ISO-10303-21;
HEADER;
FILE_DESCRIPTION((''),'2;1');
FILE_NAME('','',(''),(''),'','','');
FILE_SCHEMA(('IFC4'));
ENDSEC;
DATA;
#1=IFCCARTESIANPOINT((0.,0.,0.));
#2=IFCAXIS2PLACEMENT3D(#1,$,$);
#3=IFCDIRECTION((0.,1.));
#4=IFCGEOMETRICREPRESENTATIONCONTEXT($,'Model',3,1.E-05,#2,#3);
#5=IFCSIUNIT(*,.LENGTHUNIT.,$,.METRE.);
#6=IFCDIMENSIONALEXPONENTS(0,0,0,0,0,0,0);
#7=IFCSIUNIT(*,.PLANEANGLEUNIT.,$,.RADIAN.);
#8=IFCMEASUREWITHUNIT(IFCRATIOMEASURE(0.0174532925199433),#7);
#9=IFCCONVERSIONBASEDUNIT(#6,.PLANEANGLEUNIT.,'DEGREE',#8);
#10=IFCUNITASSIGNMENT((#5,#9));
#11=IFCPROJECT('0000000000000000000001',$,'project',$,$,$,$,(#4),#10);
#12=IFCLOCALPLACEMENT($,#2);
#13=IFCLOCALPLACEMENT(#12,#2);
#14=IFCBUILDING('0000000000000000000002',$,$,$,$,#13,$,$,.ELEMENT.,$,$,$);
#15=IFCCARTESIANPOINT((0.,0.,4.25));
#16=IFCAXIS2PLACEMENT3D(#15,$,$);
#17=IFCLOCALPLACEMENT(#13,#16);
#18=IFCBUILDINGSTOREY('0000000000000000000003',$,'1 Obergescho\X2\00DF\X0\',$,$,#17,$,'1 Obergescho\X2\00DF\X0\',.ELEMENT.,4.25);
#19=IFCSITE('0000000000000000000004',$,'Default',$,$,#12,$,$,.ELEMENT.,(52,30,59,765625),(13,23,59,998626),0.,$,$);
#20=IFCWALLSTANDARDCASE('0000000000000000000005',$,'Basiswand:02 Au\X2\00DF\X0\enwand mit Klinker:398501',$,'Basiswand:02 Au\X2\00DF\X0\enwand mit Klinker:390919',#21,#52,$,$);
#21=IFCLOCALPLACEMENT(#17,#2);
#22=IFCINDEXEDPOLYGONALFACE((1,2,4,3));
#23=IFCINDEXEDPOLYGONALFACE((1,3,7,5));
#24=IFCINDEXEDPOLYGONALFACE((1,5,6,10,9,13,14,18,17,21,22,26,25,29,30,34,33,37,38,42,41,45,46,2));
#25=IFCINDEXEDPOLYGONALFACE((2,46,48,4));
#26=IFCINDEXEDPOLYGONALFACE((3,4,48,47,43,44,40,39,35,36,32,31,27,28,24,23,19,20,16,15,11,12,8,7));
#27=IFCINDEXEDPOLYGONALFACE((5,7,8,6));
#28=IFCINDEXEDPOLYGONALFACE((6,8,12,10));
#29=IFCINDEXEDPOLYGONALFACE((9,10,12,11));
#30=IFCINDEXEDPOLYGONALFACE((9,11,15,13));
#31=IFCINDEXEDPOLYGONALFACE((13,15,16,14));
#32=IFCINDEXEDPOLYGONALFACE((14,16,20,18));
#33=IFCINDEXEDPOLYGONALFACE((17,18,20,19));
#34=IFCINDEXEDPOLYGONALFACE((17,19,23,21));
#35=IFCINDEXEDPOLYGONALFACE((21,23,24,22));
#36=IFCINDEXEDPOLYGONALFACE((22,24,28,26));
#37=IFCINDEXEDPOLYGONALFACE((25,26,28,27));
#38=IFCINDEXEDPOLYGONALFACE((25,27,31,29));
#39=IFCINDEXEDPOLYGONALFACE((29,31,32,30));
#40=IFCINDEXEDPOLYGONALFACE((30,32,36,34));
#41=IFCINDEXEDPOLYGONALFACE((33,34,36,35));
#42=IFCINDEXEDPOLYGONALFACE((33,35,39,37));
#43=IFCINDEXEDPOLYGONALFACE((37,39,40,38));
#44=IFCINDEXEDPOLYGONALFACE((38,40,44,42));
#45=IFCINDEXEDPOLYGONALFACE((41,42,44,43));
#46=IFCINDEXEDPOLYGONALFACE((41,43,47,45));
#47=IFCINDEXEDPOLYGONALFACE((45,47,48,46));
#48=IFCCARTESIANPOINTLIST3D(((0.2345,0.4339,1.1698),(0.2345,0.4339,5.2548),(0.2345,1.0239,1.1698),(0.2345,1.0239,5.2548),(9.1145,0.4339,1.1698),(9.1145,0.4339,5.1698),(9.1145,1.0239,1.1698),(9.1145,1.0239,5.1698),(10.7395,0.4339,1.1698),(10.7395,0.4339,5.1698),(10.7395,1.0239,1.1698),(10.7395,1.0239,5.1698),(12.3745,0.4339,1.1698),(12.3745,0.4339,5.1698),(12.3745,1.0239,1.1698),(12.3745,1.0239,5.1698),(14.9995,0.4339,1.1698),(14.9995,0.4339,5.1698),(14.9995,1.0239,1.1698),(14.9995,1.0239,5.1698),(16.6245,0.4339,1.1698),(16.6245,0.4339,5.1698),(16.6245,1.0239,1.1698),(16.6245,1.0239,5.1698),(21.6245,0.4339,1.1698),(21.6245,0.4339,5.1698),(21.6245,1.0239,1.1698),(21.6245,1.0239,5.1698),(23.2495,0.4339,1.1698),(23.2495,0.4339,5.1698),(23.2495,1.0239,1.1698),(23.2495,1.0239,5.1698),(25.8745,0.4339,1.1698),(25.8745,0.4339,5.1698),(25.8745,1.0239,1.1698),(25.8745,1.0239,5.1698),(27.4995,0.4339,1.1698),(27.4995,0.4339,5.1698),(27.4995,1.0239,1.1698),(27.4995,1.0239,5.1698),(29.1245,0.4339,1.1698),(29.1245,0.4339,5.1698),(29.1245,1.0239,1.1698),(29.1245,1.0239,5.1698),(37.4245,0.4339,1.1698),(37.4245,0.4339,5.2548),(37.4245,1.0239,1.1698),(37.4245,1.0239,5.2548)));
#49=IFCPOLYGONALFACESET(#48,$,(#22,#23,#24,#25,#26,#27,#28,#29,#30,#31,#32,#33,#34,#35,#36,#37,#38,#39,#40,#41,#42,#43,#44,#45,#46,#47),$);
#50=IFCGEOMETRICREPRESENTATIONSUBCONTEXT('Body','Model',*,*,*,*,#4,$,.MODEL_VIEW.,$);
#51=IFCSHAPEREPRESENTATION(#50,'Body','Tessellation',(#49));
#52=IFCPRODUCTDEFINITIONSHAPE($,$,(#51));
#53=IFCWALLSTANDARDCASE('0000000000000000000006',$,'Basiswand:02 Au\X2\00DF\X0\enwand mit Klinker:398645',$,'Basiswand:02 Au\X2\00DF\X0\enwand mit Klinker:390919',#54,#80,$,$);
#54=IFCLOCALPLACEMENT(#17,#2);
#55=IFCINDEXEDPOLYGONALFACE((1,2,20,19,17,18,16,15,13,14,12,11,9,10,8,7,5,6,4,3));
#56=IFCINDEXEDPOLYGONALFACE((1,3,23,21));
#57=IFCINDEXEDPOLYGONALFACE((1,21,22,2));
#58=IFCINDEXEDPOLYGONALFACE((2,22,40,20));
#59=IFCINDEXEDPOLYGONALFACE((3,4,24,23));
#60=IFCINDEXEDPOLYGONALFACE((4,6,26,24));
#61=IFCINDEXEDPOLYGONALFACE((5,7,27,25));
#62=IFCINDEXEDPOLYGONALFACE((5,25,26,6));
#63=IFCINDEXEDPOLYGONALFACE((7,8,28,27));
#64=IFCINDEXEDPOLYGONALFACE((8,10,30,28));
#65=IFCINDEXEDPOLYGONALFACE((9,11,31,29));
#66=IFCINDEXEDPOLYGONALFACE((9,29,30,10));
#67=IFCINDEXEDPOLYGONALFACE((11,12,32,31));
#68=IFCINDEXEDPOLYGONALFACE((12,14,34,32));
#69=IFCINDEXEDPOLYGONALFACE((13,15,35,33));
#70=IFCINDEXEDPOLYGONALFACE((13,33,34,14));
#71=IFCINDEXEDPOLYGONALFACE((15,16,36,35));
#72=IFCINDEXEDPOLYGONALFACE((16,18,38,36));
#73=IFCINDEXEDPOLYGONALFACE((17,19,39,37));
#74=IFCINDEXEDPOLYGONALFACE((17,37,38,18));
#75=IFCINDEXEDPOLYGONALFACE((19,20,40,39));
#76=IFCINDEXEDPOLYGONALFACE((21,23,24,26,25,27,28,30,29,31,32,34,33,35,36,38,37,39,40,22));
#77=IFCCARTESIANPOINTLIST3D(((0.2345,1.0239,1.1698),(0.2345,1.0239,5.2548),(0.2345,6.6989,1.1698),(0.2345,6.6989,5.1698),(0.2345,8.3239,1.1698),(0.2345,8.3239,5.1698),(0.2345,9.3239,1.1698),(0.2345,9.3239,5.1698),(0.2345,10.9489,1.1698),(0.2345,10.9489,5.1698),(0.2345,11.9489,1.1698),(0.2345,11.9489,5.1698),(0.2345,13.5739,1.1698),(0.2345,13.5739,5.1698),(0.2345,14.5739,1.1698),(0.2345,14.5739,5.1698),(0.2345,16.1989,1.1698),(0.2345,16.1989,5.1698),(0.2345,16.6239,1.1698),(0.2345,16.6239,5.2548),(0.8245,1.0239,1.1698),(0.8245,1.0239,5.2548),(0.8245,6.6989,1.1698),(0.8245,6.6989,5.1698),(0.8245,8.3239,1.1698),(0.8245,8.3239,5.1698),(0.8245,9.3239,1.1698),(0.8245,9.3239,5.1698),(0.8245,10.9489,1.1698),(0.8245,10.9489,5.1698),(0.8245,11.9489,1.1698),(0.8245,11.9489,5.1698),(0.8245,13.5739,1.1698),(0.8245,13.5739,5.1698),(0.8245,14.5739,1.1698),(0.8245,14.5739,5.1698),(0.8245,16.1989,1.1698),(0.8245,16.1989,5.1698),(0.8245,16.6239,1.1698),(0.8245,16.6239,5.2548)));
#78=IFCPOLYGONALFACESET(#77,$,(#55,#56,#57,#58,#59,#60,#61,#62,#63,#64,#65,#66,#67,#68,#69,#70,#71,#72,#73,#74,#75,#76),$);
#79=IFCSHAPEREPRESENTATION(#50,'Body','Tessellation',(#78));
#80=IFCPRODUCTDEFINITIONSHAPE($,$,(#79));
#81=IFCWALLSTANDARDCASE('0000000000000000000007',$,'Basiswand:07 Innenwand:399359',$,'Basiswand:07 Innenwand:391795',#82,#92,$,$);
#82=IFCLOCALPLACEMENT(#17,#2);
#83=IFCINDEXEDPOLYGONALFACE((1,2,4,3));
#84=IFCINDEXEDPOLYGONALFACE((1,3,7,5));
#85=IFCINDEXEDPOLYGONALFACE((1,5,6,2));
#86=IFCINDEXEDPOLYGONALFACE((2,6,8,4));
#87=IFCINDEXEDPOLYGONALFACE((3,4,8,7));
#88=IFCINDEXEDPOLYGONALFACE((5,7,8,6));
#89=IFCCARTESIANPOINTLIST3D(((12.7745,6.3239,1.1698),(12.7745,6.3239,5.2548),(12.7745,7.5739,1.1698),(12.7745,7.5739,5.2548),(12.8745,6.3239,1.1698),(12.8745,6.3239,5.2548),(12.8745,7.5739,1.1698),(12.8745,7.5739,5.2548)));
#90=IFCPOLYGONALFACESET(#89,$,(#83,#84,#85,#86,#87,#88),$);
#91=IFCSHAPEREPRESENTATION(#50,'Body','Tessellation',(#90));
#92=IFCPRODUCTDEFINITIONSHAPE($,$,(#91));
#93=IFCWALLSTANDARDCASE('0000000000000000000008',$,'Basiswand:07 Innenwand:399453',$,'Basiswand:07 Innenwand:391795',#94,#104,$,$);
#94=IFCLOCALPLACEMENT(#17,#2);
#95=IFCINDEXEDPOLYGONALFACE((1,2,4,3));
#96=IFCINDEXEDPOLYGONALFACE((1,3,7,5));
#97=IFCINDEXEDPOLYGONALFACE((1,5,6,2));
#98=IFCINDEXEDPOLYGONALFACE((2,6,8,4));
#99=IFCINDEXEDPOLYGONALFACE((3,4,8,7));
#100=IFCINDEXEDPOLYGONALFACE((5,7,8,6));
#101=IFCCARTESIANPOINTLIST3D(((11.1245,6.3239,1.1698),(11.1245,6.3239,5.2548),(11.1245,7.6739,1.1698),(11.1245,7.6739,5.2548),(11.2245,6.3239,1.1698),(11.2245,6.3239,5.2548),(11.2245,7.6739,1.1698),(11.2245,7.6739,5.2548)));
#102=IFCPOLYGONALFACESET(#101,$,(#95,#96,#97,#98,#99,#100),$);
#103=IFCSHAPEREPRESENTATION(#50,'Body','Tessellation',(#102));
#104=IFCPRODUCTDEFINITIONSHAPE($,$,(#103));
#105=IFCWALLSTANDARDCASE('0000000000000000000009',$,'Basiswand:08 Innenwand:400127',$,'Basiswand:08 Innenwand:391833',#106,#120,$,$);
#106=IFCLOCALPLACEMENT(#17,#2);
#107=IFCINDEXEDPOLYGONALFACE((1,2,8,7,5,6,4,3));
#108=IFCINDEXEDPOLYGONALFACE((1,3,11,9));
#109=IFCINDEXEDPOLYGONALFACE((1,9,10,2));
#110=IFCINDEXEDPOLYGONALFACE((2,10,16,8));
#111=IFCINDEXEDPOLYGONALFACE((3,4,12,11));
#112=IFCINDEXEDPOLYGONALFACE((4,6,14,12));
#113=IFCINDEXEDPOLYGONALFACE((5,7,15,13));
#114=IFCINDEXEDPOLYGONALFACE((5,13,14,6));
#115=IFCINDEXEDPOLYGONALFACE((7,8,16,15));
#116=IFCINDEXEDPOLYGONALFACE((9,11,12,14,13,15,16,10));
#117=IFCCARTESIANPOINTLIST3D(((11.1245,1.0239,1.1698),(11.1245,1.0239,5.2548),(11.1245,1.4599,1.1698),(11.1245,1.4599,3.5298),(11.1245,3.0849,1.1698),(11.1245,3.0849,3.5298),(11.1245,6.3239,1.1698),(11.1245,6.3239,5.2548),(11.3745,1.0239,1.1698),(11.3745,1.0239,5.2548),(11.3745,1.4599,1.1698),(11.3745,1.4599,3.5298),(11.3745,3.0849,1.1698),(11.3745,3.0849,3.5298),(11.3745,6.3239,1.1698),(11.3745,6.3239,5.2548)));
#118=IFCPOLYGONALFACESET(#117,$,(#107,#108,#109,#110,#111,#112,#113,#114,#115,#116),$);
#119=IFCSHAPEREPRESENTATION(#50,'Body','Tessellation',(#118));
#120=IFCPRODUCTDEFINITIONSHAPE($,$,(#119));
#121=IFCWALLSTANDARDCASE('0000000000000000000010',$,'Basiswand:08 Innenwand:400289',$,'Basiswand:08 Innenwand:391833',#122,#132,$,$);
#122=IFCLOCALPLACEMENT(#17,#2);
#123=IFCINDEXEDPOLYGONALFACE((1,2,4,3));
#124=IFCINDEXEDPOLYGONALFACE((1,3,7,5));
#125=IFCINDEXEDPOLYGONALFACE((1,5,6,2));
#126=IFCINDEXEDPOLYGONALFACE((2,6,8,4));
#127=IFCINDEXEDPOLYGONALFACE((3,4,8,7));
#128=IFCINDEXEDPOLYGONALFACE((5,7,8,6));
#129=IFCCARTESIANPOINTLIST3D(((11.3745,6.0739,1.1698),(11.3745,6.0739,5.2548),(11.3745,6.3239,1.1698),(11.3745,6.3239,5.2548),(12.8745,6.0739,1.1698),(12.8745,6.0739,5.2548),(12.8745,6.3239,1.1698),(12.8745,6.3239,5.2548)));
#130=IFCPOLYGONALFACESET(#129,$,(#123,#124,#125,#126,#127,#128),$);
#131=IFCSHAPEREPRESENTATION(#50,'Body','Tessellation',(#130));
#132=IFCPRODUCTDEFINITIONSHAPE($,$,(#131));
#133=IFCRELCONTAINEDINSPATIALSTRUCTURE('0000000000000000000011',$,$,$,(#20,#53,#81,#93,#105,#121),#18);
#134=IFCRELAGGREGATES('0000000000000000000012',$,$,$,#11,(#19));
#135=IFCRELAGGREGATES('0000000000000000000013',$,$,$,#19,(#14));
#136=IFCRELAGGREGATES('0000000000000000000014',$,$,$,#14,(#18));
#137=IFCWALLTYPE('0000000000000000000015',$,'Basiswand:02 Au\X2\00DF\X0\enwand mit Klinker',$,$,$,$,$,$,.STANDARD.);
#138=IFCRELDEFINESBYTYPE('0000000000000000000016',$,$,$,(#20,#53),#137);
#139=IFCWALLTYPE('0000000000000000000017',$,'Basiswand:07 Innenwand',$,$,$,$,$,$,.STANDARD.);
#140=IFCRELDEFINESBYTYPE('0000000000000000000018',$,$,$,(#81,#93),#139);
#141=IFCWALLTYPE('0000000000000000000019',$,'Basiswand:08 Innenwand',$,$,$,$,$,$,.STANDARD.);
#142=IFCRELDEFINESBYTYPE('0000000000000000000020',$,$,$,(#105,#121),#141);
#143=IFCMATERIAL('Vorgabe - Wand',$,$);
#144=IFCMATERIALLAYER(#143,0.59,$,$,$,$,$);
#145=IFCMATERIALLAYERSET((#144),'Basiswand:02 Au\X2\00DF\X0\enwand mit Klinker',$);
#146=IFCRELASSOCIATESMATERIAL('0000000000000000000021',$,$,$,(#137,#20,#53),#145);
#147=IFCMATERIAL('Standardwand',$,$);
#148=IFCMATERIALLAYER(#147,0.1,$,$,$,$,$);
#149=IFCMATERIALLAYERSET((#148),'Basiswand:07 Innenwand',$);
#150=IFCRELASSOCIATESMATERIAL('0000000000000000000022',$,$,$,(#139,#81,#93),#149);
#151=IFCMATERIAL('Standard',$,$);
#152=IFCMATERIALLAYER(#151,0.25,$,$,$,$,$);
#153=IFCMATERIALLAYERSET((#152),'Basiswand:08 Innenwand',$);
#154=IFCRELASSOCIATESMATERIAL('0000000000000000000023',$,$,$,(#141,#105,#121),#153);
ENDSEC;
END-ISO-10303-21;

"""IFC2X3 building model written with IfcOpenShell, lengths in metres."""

from ifc_helpers import new_model, entity, si_unit, converted_unit, direction, frame, frame_2d, origin, place, context, subcontext, project, spatial, polyline, rectangle, extrude, clip, bounded_halfspace, material, layer, layer_set, layer_usage, type_object, element, save


model = new_model("IFC2X3")

# Units and contexts
model_context = context("Model", 3, precision=1e-05, world=origin(), true_north=direction((0.0, 1.0)))
body_context = subcontext(model_context, "Body", "Model", "MODEL_VIEW")
ifc_project = project(units=[si_unit("LENGTHUNIT", "METRE"), converted_unit("PLANEANGLEUNIT", "DEGREE", entity("IfcRatioMeasure", 0.0174532925199433), si_unit("PLANEANGLEUNIT", "RADIAN"), dimensions=[0, 0, 0, 0, 0, 0, 0])], contexts=[model_context])

# Site, building, storey
site_placement = place(None, origin())
site = spatial("IfcSite", under=ifc_project, at=site_placement, Name="Default", CompositionType="ELEMENT", RefLatitude=(52, 30, 59, 765625), RefLongitude=(13, 23, 59, 998626), RefElevation=0.0)
building_placement = place(site_placement, origin())
building = spatial("IfcBuilding", under=site, at=building_placement, CompositionType="ELEMENT")
storey_placement = place(building_placement, frame((0.0, 0.0, 4.25)))
storey = spatial("IfcBuildingStorey", under=building, at=storey_placement, Name="1 Obergeschoß", LongName="1 Obergeschoß", CompositionType="ELEMENT", Elevation=4.25)

# Walls, openings
ifc_material_1 = material(Name="Vorgabe - Wand")
ifc_layer_1 = layer(ifc_material_1, 0.59)
ifc_layer_set_1 = layer_set([ifc_layer_1], Name="Basiswand:02 Außenwand mit Klinker")
ifc_layer_usage_1 = layer_usage(ifc_layer_set_1, "AXIS2", "NEGATIVE", 0.295)
wall_type_1 = type_object("IfcWallType", Name="Basiswand:02 Außenwand mit Klinker", PredefinedType="STANDARD", material=ifc_layer_set_1)
wall_1_placement = place(storey_placement, frame((37.4245, 0.7289, 1.1698), z_axis=(0.0, 0.0, 1.0), x_axis=(-1.0, 0.0, 0.0)))
wall_1 = element("IfcWallStandardCase", 1, at=wall_1_placement, inside=storey, type_object=wall_type_1, material=ifc_layer_usage_1, Name="Basiswand:02 Außenwand mit Klinker:398501", ObjectType="Basiswand:02 Außenwand mit Klinker:390919", context=body_context, shape_type="Clipping", body=[
    clip(extrude(rectangle(XDim=37.19, YDim=0.59, at=frame_2d((18.595, 0.0), x_axis=(-1.0, 0.0))), origin(), (0.0, 0.0, 1.0), 4.085), bounded_halfspace(frame((0.0, -0.295, 4.085), z_axis=(0.0, 0.0, -1.0), x_axis=(0.0, 1.0, 0.0)), True, frame((0.0, -0.295, 4.085)), polyline([(0.0, 0.0), (10.3, 0.0), (10.55, 0.0), (26.05, 0.0), (26.3, 0.0), (36.6, 0.0), (37.19, 0.0), (37.19, 0.59), (0.0, 0.59), (0.0, 0.0)]))),
])
opening_1_placement = place(wall_1_placement, frame((11.55, -0.295, 0.0)))
element("IfcOpeningElement", 2, at=opening_1_placement, cuts=wall_1, ObjectType="Opening", context=body_context, shape_type="SweptSolid", body=[
    extrude(rectangle(XDim=4.0, YDim=2.625, at=frame_2d((2.0, 1.3125), x_axis=(1.0, 0.0))), frame((0.0, 0.0, 0.0), z_axis=(0.0, 1.0, 0.0), x_axis=(0.0, 0.0, 1.0)), (0.0, 0.0, 1.0), 0.59),
])
opening_2_placement = place(wall_1_placement, frame((22.425, -0.295, 0.0)))
element("IfcOpeningElement", 3, at=opening_2_placement, cuts=wall_1, ObjectType="Opening", context=body_context, shape_type="SweptSolid", body=[
    extrude(rectangle(XDim=4.0, YDim=2.625, at=frame_2d((2.0, 1.3125), x_axis=(1.0, 0.0))), frame((0.0, 0.0, 0.0), z_axis=(0.0, 1.0, 0.0), x_axis=(0.0, 0.0, 1.0)), (0.0, 0.0, 1.0), 0.59),
])
opening_3_placement = place(wall_1_placement, frame((26.685, -0.295, 0.0)))
element("IfcOpeningElement", 4, at=opening_3_placement, cuts=wall_1, ObjectType="Opening", context=body_context, shape_type="SweptSolid", body=[
    extrude(rectangle(XDim=4.0, YDim=1.625, at=frame_2d((2.0, 0.8125), x_axis=(1.0, 0.0))), frame((0.0, 0.0, 0.0), z_axis=(0.0, 1.0, 0.0), x_axis=(0.0, 0.0, 1.0)), (0.0, 0.0, 1.0), 0.59),
])
opening_4_placement = place(wall_1_placement, frame((8.3, -0.295, 0.0)))
element("IfcOpeningElement", 5, at=opening_4_placement, cuts=wall_1, ObjectType="Opening", context=body_context, shape_type="SweptSolid", body=[
    extrude(rectangle(XDim=4.0, YDim=1.625, at=frame_2d((2.0, 0.8125), x_axis=(1.0, 0.0))), frame((0.0, 0.0, 0.0), z_axis=(0.0, 1.0, 0.0), x_axis=(0.0, 0.0, 1.0)), (0.0, 0.0, 1.0), 0.59),
])
opening_5_placement = place(wall_1_placement, frame((15.8, -0.295, 0.0)))
element("IfcOpeningElement", 6, at=opening_5_placement, cuts=wall_1, ObjectType="Opening", context=body_context, shape_type="SweptSolid", body=[
    extrude(rectangle(XDim=4.0, YDim=5.0, at=frame_2d((2.0, 2.5), x_axis=(1.0, 0.0))), frame((0.0, 0.0, 0.0), z_axis=(0.0, 1.0, 0.0), x_axis=(0.0, 0.0, 1.0)), (0.0, 0.0, 1.0), 0.59),
])
ifc_layer_usage_2 = layer_usage(ifc_layer_set_1, "AXIS2", "NEGATIVE", 0.295)
wall_2_placement = place(storey_placement, frame((0.5295, 1.0239, 1.1698), z_axis=(0.0, 0.0, 1.0), x_axis=(0.0, 1.0, 0.0)))
wall_2 = element("IfcWallStandardCase", 7, at=wall_2_placement, inside=storey, type_object=wall_type_1, material=ifc_layer_usage_2, Name="Basiswand:02 Außenwand mit Klinker:398645", ObjectType="Basiswand:02 Außenwand mit Klinker:390919", context=body_context, shape_type="Clipping", body=[
    clip(extrude(rectangle(XDim=15.6, YDim=0.59, at=frame_2d((7.8, 0.0), x_axis=(-1.0, 0.0))), origin(), (0.0, 0.0, 1.0), 4.085), bounded_halfspace(frame((0.0, -0.295, 4.085), z_axis=(0.0, 0.0, -1.0), x_axis=(-1.0, 0.0, 0.0)), True, frame((0.0, -0.295, 4.085)), polyline([(0.0, 0.0), (15.6, 0.0), (15.6, 0.59), (0.0, 0.59), (0.0, 0.0)]))),
])
opening_6_placement = place(wall_2_placement, frame((13.55, -0.295, 0.0)))
element("IfcOpeningElement", 8, at=opening_6_placement, cuts=wall_2, ObjectType="Opening", context=body_context, shape_type="SweptSolid", body=[
    extrude(rectangle(XDim=4.0, YDim=1.625, at=frame_2d((2.0, 0.8125), x_axis=(1.0, 0.0))), frame((0.0, 0.0, 0.0), z_axis=(0.0, 1.0, 0.0), x_axis=(0.0, 0.0, 1.0)), (0.0, 0.0, 1.0), 0.59),
])
opening_7_placement = place(wall_2_placement, frame((10.925, -0.295, 0.0)))
element("IfcOpeningElement", 9, at=opening_7_placement, cuts=wall_2, ObjectType="Opening", context=body_context, shape_type="SweptSolid", body=[
    extrude(rectangle(XDim=4.0, YDim=1.625, at=frame_2d((2.0, 0.8125), x_axis=(1.0, 0.0))), frame((0.0, 0.0, 0.0), z_axis=(0.0, 1.0, 0.0), x_axis=(0.0, 0.0, 1.0)), (0.0, 0.0, 1.0), 0.59),
])
opening_8_placement = place(wall_2_placement, frame((8.3, -0.295, 0.0)))
element("IfcOpeningElement", 10, at=opening_8_placement, cuts=wall_2, ObjectType="Opening", context=body_context, shape_type="SweptSolid", body=[
    extrude(rectangle(XDim=4.0, YDim=1.625, at=frame_2d((2.0, 0.8125), x_axis=(1.0, 0.0))), frame((0.0, 0.0, 0.0), z_axis=(0.0, 1.0, 0.0), x_axis=(0.0, 0.0, 1.0)), (0.0, 0.0, 1.0), 0.59),
])
opening_9_placement = place(wall_2_placement, frame((5.675, -0.295, 0.0)))
element("IfcOpeningElement", 11, at=opening_9_placement, cuts=wall_2, ObjectType="Opening", context=body_context, shape_type="SweptSolid", body=[
    extrude(rectangle(XDim=4.0, YDim=1.625, at=frame_2d((2.0, 0.8125), x_axis=(1.0, 0.0))), frame((0.0, 0.0, 0.0), z_axis=(0.0, 1.0, 0.0), x_axis=(0.0, 0.0, 1.0)), (0.0, 0.0, 1.0), 0.59),
])

# Walls
ifc_material_2 = material(Name="Standardwand")
ifc_layer_2 = layer(ifc_material_2, 0.1)
ifc_layer_set_2 = layer_set([ifc_layer_2], Name="Basiswand:07 Innenwand")
ifc_layer_usage_3 = layer_usage(ifc_layer_set_2, "AXIS2", "NEGATIVE", 0.05)
wall_type_2 = type_object("IfcWallType", Name="Basiswand:07 Innenwand", PredefinedType="STANDARD", material=ifc_layer_set_2)
wall_3_placement = place(storey_placement, frame((12.8245, 6.3239, 1.1698), z_axis=(0.0, 0.0, 1.0), x_axis=(0.0, 1.0, 0.0)))
element("IfcWallStandardCase", 12, at=wall_3_placement, inside=storey, type_object=wall_type_2, material=ifc_layer_usage_3, Name="Basiswand:07 Innenwand:399359", ObjectType="Basiswand:07 Innenwand:391795", context=body_context, shape_type="Clipping", body=[
    clip(extrude(rectangle(XDim=1.25, YDim=0.1, at=frame_2d((0.625, 0.0), x_axis=(-1.0, 0.0))), origin(), (0.0, 0.0, 1.0), 4.085), bounded_halfspace(frame((0.0, -0.05, 4.085), z_axis=(0.0, 0.0, -1.0), x_axis=(-1.0, 0.0, 0.0)), True, frame((0.0, -0.05, 4.085)), polyline([(0.0, 0.0), (1.25, 0.0), (1.25, 0.1), (0.0, 0.1), (0.0, 0.0)]))),
])
ifc_layer_usage_4 = layer_usage(ifc_layer_set_2, "AXIS2", "NEGATIVE", 0.05)
wall_4_placement = place(storey_placement, frame((11.1745, 6.3239, 1.1698), z_axis=(0.0, 0.0, 1.0), x_axis=(0.0, 1.0, 0.0)))
element("IfcWallStandardCase", 13, at=wall_4_placement, inside=storey, type_object=wall_type_2, material=ifc_layer_usage_4, Name="Basiswand:07 Innenwand:399453", ObjectType="Basiswand:07 Innenwand:391795", context=body_context, shape_type="Clipping", body=[
    clip(extrude(rectangle(XDim=1.35, YDim=0.1, at=frame_2d((0.675, 0.0), x_axis=(-1.0, 0.0))), origin(), (0.0, 0.0, 1.0), 4.085), bounded_halfspace(frame((0.0, -0.05, 4.085), z_axis=(0.0, 0.0, -1.0), x_axis=(-1.0, 0.0, 0.0)), True, frame((0.0, -0.05, 4.085)), polyline([(0.0, 0.0), (1.25, 0.0), (1.35, 0.0), (1.35, 0.1), (0.0, 0.1), (0.0, 0.0)]))),
])

# Wall, opening
ifc_material_3 = material(Name="Standard")
ifc_layer_3 = layer(ifc_material_3, 0.25)
ifc_layer_set_3 = layer_set([ifc_layer_3], Name="Basiswand:08 Innenwand")
ifc_layer_usage_5 = layer_usage(ifc_layer_set_3, "AXIS2", "NEGATIVE", 0.125)
wall_type_3 = type_object("IfcWallType", Name="Basiswand:08 Innenwand", PredefinedType="STANDARD", material=ifc_layer_set_3)
wall_5_placement = place(storey_placement, frame((11.2495, 1.0239, 1.1698), z_axis=(0.0, 0.0, 1.0), x_axis=(0.0, 1.0, 0.0)))
wall_5 = element("IfcWallStandardCase", 14, at=wall_5_placement, inside=storey, type_object=wall_type_3, material=ifc_layer_usage_5, Name="Basiswand:08 Innenwand:400127", ObjectType="Basiswand:08 Innenwand:391833", context=body_context, shape_type="Clipping", body=[
    clip(extrude(rectangle(XDim=5.3, YDim=0.25, at=frame_2d((2.65, 0.0), x_axis=(-1.0, 0.0))), origin(), (0.0, 0.0, 1.0), 4.085), bounded_halfspace(frame((0.0, -0.125, 4.085), z_axis=(0.0, 0.0, -1.0), x_axis=(-1.0, 0.0, 0.0)), True, frame((0.0, -0.125, 4.085)), polyline([(0.0, 0.0), (5.05, 0.0), (5.3, 0.0), (5.3, 0.15), (5.3, 0.25), (0.0, 0.25), (0.0, 0.0)]))),
])
opening_10_placement = place(wall_5_placement, frame((2.061, 0.125, 0.0)))
element("IfcOpeningElement", 15, at=opening_10_placement, cuts=wall_5, ObjectType="Opening", context=body_context, shape_type="SweptSolid", body=[
    extrude(rectangle(XDim=2.36, YDim=1.625, at=frame_2d((1.18, 0.8125), x_axis=(1.0, 0.0))), frame((0.0, 0.0, 0.0), z_axis=(0.0, -1.0, 0.0), x_axis=(0.0, 0.0, 1.0)), (0.0, 0.0, 1.0), 0.25),
])

# Wall
ifc_layer_usage_6 = layer_usage(ifc_layer_set_3, "AXIS2", "NEGATIVE", 0.125)
wall_6_placement = place(storey_placement, frame((11.3745, 6.1989, 1.1698), z_axis=(0.0, 0.0, 1.0), x_axis=(1.0, 0.0, 0.0)))
element("IfcWallStandardCase", 16, at=wall_6_placement, inside=storey, type_object=wall_type_3, material=ifc_layer_usage_6, Name="Basiswand:08 Innenwand:400289", ObjectType="Basiswand:08 Innenwand:391833", context=body_context, shape_type="Clipping", body=[
    clip(extrude(rectangle(XDim=1.5, YDim=0.25, at=frame_2d((0.75, 0.0), x_axis=(-1.0, 0.0))), origin(), (0.0, 0.0, 1.0), 4.085), bounded_halfspace(frame((0.0, -0.125, 4.085), z_axis=(0.0, 0.0, -1.0), x_axis=(0.0, -1.0, 0.0)), True, frame((0.0, -0.125, 4.085)), polyline([(0.0, 0.0), (1.5, 0.0), (1.5, 0.25), (1.4, 0.25), (0.0, 0.25), (0.0, 0.0)]))),
])

save(model, "model.ifc")
